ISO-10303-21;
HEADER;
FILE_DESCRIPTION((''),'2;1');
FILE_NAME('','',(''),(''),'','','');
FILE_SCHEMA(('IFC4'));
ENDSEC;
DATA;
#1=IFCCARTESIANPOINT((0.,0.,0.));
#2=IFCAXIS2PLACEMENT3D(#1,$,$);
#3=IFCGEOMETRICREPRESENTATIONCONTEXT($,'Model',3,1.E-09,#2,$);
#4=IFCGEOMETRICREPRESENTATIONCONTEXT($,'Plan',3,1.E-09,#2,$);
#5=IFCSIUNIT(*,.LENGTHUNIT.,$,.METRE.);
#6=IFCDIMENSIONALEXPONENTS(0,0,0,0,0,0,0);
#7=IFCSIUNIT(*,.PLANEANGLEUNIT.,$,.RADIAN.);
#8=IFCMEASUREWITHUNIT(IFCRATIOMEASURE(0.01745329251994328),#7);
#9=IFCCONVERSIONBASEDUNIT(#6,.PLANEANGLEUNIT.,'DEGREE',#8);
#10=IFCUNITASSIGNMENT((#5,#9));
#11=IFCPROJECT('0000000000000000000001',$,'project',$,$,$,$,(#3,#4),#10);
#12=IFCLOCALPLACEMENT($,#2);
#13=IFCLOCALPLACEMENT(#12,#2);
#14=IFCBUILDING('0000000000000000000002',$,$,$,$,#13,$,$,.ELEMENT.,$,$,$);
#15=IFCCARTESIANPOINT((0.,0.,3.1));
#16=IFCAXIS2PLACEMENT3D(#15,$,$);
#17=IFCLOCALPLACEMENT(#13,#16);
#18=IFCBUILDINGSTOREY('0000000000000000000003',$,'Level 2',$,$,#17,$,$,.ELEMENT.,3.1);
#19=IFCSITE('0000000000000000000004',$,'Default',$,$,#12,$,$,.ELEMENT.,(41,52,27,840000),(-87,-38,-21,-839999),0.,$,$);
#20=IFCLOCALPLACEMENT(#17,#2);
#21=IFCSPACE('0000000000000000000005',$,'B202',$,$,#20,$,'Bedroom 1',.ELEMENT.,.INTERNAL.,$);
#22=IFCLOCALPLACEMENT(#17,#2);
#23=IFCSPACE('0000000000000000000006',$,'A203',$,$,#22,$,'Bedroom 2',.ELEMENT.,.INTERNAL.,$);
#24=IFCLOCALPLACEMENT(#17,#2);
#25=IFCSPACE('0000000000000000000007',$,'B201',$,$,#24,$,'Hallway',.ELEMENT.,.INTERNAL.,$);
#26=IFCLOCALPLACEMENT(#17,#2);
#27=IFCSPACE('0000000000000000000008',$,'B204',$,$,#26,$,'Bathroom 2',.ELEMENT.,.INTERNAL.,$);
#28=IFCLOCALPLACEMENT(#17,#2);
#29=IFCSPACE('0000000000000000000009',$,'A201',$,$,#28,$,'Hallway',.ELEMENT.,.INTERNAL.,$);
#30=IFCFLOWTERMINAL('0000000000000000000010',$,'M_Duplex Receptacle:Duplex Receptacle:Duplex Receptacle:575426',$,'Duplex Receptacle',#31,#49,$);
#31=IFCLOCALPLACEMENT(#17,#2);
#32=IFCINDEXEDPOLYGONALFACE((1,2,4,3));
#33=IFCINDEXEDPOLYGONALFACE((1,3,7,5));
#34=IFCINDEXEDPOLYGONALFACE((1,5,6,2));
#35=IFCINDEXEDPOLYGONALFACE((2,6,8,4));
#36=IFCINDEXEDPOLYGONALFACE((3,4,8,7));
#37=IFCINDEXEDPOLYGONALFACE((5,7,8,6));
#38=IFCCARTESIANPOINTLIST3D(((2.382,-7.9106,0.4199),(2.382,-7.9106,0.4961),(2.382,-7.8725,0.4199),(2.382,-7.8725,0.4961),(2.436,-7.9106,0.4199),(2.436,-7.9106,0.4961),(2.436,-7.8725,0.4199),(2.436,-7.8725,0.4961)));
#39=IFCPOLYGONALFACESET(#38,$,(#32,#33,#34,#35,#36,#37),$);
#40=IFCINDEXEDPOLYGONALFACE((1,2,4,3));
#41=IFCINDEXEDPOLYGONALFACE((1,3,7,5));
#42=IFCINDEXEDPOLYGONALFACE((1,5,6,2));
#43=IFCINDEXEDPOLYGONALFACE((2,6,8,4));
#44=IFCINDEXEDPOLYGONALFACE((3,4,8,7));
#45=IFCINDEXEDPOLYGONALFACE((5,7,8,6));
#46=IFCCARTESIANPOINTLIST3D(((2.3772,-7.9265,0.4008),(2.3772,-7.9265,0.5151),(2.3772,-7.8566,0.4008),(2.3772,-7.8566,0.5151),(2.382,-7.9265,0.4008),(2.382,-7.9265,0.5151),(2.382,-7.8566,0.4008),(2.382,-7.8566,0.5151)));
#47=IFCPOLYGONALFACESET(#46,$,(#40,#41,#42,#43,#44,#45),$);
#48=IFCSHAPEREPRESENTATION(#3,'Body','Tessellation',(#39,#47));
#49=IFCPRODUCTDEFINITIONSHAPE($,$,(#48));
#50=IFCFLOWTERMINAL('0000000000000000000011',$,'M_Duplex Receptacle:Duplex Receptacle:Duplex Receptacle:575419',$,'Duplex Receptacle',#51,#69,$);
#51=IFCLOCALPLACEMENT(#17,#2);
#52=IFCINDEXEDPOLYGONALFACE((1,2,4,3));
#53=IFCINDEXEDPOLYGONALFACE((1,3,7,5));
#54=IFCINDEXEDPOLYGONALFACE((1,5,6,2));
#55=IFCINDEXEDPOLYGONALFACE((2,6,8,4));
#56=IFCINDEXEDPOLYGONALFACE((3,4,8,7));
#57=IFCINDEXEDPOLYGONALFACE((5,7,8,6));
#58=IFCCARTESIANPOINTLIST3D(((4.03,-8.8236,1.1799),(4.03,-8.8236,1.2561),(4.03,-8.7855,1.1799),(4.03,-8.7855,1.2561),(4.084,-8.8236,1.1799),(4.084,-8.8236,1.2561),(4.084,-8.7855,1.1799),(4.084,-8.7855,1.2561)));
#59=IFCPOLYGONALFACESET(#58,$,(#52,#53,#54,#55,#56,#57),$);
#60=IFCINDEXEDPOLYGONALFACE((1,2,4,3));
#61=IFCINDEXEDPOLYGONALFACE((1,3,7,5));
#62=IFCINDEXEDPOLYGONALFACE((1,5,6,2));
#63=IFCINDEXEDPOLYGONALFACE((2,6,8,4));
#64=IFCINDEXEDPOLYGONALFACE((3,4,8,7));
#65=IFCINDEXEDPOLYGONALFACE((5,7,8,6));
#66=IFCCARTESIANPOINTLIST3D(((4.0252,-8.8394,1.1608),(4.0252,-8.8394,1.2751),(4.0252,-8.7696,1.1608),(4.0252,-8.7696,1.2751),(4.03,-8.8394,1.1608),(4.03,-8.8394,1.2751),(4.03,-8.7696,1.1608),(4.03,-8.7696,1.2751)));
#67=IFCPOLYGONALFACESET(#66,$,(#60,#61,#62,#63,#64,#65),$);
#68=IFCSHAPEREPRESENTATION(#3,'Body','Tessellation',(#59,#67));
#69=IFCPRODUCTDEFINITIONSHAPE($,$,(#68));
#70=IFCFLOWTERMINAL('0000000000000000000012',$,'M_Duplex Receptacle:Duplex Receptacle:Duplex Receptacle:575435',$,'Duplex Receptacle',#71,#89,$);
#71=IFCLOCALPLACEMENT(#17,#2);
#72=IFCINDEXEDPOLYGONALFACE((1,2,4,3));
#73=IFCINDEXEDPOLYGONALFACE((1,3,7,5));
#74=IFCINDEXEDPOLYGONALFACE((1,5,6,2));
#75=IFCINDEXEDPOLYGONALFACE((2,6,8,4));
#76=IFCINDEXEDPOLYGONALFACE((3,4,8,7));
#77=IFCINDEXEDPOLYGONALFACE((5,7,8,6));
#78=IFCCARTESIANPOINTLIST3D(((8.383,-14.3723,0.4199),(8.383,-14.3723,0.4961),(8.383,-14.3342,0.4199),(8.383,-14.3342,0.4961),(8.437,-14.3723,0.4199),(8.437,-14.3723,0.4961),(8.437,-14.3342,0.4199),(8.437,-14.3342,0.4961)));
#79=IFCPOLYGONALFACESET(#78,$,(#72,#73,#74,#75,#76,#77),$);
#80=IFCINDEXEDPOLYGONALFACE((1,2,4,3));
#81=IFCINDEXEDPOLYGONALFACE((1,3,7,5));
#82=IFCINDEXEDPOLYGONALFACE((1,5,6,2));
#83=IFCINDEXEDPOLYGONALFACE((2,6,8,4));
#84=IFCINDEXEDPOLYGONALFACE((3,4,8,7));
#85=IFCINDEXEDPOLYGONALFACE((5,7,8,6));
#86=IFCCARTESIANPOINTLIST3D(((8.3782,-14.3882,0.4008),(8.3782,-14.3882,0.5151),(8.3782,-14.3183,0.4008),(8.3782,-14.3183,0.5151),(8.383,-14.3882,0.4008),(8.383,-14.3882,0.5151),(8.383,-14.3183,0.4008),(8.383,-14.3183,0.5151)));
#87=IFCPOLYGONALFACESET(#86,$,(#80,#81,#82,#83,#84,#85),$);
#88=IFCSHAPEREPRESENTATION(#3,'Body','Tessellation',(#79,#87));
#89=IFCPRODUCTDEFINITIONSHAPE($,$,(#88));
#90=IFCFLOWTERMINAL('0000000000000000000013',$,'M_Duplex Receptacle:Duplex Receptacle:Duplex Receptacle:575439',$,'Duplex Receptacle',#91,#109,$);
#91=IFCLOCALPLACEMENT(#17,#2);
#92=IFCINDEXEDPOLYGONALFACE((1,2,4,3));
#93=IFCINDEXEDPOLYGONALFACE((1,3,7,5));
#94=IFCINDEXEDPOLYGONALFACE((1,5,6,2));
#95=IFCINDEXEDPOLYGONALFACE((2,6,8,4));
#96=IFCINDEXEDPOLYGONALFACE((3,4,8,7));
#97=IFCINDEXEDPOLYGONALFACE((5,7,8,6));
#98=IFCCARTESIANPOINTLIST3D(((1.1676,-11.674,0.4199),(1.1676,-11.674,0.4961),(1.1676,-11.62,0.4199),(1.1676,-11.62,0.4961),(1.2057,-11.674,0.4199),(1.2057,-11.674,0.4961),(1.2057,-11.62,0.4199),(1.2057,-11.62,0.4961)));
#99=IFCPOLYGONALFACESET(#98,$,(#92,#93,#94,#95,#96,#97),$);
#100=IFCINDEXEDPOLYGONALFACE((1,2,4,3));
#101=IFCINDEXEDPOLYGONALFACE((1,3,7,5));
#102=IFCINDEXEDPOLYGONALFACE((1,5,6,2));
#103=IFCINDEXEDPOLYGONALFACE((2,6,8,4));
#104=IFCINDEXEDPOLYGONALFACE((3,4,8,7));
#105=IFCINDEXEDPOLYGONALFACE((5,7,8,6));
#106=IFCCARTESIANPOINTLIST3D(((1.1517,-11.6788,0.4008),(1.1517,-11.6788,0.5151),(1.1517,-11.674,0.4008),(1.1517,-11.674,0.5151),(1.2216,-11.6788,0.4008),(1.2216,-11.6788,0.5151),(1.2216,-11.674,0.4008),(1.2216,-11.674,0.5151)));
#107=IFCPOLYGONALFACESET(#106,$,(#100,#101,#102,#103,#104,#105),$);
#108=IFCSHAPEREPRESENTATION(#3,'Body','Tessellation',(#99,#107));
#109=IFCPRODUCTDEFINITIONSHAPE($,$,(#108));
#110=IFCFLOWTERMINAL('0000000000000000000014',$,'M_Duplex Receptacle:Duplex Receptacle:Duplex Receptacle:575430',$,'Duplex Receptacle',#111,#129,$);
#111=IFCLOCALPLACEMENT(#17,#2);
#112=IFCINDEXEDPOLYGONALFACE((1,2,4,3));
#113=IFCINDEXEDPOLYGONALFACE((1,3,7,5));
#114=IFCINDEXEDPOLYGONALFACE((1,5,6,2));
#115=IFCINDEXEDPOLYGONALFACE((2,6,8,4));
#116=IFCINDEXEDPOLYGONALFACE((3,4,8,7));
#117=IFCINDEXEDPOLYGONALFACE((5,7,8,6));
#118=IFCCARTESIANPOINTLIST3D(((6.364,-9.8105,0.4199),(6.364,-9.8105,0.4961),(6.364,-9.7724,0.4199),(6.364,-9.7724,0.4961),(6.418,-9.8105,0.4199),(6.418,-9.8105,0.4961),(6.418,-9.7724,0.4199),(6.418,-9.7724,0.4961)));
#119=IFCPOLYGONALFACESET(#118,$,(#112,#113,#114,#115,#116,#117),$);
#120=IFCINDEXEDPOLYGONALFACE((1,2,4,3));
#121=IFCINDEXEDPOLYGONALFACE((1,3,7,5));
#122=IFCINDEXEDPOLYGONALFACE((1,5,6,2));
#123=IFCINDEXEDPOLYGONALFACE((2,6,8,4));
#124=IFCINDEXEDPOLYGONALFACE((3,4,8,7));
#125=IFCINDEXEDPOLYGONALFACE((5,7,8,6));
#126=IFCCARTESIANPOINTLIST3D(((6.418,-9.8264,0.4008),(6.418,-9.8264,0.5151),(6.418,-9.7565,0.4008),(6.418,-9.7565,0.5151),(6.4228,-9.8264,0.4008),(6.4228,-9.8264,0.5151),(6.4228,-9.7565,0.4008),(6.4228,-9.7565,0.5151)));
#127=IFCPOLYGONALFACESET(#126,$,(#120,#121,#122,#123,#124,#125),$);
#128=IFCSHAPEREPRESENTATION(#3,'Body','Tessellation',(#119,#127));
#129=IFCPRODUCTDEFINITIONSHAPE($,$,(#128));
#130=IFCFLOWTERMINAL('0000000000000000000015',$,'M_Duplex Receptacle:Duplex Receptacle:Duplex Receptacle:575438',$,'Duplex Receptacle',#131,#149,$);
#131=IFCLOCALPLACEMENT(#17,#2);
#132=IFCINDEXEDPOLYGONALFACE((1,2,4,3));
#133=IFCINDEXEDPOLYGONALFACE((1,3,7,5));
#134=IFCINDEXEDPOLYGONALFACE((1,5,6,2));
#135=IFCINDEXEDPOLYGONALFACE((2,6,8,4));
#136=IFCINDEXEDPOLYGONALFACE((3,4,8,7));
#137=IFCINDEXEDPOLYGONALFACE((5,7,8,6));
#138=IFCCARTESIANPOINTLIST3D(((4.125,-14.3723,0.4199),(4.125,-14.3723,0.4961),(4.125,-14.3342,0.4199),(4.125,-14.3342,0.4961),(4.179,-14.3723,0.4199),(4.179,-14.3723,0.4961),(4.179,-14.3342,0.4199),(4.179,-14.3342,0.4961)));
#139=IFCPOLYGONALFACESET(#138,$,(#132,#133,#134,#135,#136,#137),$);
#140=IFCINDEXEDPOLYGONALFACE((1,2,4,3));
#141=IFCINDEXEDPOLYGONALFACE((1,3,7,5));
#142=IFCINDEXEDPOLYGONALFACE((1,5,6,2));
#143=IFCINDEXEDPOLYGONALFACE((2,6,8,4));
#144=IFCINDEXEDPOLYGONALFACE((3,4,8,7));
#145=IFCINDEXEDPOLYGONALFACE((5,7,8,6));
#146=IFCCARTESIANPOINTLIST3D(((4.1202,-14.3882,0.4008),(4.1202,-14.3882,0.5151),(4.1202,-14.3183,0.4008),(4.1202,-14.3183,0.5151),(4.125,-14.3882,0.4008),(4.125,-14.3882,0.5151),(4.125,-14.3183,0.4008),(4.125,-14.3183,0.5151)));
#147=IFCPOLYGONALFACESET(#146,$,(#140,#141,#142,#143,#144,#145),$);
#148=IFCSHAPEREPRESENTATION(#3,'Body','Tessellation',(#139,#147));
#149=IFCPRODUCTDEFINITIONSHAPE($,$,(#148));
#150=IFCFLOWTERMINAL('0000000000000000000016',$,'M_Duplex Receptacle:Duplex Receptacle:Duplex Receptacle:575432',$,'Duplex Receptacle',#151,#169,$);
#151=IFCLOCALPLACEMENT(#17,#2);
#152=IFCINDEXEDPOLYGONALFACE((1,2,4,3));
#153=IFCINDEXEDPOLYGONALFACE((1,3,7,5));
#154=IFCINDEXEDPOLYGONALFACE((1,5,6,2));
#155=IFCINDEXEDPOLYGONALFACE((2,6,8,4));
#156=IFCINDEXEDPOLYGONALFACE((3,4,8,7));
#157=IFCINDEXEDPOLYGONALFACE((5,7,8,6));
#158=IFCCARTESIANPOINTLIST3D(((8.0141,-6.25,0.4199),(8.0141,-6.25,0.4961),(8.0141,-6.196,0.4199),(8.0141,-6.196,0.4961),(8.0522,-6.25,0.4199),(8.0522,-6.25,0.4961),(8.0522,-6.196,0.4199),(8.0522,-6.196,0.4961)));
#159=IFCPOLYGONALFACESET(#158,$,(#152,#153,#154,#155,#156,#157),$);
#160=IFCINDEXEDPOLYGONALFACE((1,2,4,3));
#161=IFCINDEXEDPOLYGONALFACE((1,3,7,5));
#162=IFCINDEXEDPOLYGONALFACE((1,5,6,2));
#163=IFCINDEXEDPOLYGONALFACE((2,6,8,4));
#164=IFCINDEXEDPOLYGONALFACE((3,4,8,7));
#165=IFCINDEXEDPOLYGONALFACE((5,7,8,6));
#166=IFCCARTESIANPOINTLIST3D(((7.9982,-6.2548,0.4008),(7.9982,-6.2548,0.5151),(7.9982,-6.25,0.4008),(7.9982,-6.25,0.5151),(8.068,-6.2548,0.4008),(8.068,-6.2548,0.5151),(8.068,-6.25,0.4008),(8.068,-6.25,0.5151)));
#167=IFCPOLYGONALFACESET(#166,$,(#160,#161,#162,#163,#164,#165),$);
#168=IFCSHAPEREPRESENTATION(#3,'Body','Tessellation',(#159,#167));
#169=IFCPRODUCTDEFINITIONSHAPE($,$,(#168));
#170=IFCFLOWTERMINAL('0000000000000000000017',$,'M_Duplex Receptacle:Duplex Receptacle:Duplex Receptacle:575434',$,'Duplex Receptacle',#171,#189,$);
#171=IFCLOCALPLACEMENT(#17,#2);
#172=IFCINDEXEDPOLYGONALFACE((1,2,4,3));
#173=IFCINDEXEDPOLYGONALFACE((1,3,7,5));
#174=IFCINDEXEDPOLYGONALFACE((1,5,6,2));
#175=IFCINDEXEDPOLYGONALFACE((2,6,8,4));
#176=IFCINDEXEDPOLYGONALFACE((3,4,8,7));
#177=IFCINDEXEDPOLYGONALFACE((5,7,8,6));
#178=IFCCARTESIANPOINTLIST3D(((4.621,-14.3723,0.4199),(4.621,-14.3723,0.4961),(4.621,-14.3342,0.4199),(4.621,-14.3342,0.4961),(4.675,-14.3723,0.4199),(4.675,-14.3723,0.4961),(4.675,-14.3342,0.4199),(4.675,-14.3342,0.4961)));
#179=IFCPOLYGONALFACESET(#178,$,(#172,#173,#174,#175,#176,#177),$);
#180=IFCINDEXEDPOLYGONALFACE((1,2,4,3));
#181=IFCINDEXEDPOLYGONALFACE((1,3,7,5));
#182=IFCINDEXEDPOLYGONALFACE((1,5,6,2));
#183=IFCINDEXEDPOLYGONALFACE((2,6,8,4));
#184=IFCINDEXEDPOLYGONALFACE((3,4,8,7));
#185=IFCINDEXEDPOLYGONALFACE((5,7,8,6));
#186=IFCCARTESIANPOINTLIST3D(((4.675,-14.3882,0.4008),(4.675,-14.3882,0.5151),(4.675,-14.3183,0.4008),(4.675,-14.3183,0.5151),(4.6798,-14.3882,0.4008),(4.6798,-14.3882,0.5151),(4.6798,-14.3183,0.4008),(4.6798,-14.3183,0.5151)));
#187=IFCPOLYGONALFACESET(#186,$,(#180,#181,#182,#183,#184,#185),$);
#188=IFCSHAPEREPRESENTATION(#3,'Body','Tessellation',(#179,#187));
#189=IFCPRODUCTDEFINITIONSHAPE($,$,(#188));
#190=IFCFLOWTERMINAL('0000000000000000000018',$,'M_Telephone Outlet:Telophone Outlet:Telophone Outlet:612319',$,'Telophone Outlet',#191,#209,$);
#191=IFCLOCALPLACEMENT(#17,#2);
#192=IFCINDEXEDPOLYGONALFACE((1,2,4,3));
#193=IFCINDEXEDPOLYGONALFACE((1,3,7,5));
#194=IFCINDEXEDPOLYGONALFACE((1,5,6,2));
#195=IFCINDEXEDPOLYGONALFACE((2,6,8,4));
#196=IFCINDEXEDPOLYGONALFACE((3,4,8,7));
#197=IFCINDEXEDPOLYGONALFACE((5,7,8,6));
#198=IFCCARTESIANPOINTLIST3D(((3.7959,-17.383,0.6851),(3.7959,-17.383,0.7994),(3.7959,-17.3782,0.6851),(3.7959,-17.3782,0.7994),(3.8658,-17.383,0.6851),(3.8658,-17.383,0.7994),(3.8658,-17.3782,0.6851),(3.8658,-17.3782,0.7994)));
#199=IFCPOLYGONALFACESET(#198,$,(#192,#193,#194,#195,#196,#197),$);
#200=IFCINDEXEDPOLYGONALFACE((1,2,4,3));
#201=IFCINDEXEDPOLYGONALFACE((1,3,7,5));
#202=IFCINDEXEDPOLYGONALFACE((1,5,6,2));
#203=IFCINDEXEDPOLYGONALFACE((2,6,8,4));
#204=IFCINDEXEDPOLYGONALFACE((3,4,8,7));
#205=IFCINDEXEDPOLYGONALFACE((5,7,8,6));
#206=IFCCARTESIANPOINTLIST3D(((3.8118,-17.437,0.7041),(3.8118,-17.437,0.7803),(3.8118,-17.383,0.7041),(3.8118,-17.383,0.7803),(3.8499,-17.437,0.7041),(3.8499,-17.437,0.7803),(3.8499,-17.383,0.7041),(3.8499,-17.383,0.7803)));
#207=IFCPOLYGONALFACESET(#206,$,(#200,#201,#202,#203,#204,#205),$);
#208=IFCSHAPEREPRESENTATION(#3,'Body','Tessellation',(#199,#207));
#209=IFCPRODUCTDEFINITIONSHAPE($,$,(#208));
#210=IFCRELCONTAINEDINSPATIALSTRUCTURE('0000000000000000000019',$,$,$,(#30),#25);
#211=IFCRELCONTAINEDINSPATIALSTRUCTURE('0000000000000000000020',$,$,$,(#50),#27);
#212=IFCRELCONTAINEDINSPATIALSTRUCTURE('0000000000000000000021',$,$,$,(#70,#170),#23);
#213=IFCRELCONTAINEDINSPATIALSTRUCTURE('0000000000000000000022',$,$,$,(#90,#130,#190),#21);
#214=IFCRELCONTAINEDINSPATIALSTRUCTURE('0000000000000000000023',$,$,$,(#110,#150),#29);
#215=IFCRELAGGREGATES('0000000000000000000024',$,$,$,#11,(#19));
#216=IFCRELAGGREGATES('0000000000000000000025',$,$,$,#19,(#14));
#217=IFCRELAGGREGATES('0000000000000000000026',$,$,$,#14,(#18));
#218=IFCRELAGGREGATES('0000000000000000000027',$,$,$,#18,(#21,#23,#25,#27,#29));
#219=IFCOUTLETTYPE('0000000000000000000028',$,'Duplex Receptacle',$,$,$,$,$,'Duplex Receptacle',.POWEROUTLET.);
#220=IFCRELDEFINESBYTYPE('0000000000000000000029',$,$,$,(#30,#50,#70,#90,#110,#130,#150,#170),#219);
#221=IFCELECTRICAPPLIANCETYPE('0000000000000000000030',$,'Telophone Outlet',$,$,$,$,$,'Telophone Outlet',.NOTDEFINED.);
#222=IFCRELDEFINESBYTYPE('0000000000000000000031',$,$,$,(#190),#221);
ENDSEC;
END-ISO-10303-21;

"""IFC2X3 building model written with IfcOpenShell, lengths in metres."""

from ifc_helpers import new_model, entity, si_unit, converted_unit, frame, origin, origin_2d_with_axis, place, context, project, spatial, rectangle, extrude, source, transform, mapped, type_object, type_shapes, element, save


model = new_model("IFC2X3")

# Units and contexts
model_context = context("Model", 3, precision=1e-09, world=origin())
plan_context = context("Plan", 3, precision=1e-09, world=origin())
ifc_project = project(units=[si_unit("LENGTHUNIT", "METRE"), converted_unit("PLANEANGLEUNIT", "DEGREE", entity("IfcRatioMeasure", 0.01745329251994328), si_unit("PLANEANGLEUNIT", "RADIAN"), dimensions=[0, 0, 0, 0, 0, 0, 0])], contexts=[model_context, plan_context])

# Site, building, storey, space
site_placement = place(None, origin())
site = spatial("IfcSite", under=ifc_project, at=site_placement, Name="Default", CompositionType="ELEMENT", RefLatitude=(41, 52, 27, 840000), RefLongitude=(-87, -38, -21, -839999), RefElevation=0.0)
building_placement = place(site_placement, origin())
building = spatial("IfcBuilding", under=site, at=building_placement, CompositionType="ELEMENT")
storey_placement = place(building_placement, frame((0.0, 0.0, 3.1)))
storey = spatial("IfcBuildingStorey", under=building, at=storey_placement, Name="Level 2", CompositionType="ELEMENT", Elevation=3.1)
space_1_placement = place(storey_placement, origin())
space_1 = spatial("IfcSpace", under=storey, at=space_1_placement, Name="B202", LongName="Bedroom 1", CompositionType="ELEMENT", InteriorOrExteriorSpace="INTERNAL")

# Shared definitions
shared_shape_1 = source(origin(), model_context, "Body", "SweptSolid", [
    extrude(rectangle(XDim=0.0381, YDim=0.0762, at=origin_2d_with_axis()), frame((0.0, 0.0, -0.054), z_axis=(0.0, 0.0, 1.0), x_axis=(-1.0, 0.0, 0.0)), (0.0, 0.0, 1.0), 0.054),
    extrude(rectangle(XDim=0.0698, YDim=0.1143, at=origin_2d_with_axis()), frame((0.0, 0.0, 0.0), z_axis=(0.0, 0.0, 1.0), x_axis=(-1.0, 0.0, 0.0)), (0.0, 0.0, 1.0), 0.0048),
])

# Shared definitions
space_2_placement = place(storey_placement, origin())
space_2 = spatial("IfcSpace", under=storey, at=space_2_placement, Name="A203", LongName="Bedroom 2", CompositionType="ELEMENT", InteriorOrExteriorSpace="INTERNAL")

# Shared definitions
space_3_placement = place(storey_placement, origin())
space_3 = spatial("IfcSpace", under=storey, at=space_3_placement, Name="B201", LongName="Hallway", CompositionType="ELEMENT", InteriorOrExteriorSpace="INTERNAL")

# Shared definitions
space_4_placement = place(storey_placement, origin())
space_4 = spatial("IfcSpace", under=storey, at=space_4_placement, Name="B204", LongName="Bathroom 2", CompositionType="ELEMENT", InteriorOrExteriorSpace="INTERNAL")

# Shared definitions
space_5_placement = place(storey_placement, origin())
space_5 = spatial("IfcSpace", under=storey, at=space_5_placement, Name="A201", LongName="Hallway", CompositionType="ELEMENT", InteriorOrExteriorSpace="INTERNAL")

# Flow terminals
outlet_type = type_object("IfcOutletType", Name="Duplex Receptacle", ElementType="Duplex Receptacle", PredefinedType="POWEROUTLET")
type_shapes(outlet_type, [shared_shape_1])
flow_terminal_1_placement = place(space_3_placement, frame((2.382, -7.8916, 0.458), z_axis=(-1.0, 0.0, 0.0), x_axis=(0.0, -1.0, 0.0)))
element("IfcFlowTerminal", 1, at=flow_terminal_1_placement, inside=space_3, type_object=outlet_type, Name="M_Duplex Receptacle:Duplex Receptacle:Duplex Receptacle:575426", ObjectType="Duplex Receptacle", context=model_context, shape_type="MappedRepresentation", body=[
    mapped(shared_shape_1, transform((0.0, 0.0, 0.0), scale=1.0)),
])
flow_terminal_2_placement = place(space_4_placement, frame((4.03, -8.8045, 1.218), z_axis=(-1.0, 0.0, 0.0), x_axis=(0.0, -1.0, 0.0)))
element("IfcFlowTerminal", 2, at=flow_terminal_2_placement, inside=space_4, type_object=outlet_type, Name="M_Duplex Receptacle:Duplex Receptacle:Duplex Receptacle:575419", ObjectType="Duplex Receptacle", context=model_context, shape_type="MappedRepresentation", body=[
    mapped(shared_shape_1, transform((0.0, 0.0, 0.0), scale=1.0)),
])
flow_terminal_3_placement = place(space_2_placement, frame((8.383, -14.3533, 0.458), z_axis=(-1.0, 0.0, 0.0), x_axis=(0.0, -1.0, 0.0)))
element("IfcFlowTerminal", 3, at=flow_terminal_3_placement, inside=space_2, type_object=outlet_type, Name="M_Duplex Receptacle:Duplex Receptacle:Duplex Receptacle:575435", ObjectType="Duplex Receptacle", context=model_context, shape_type="MappedRepresentation", body=[
    mapped(shared_shape_1, transform((0.0, 0.0, 0.0), scale=1.0)),
])
flow_terminal_4_placement = place(space_1_placement, frame((1.1866, -11.674, 0.458), z_axis=(0.0, -1.0, 0.0), x_axis=(1.0, 0.0, 0.0)))
element("IfcFlowTerminal", 4, at=flow_terminal_4_placement, inside=space_1, type_object=outlet_type, Name="M_Duplex Receptacle:Duplex Receptacle:Duplex Receptacle:575439", ObjectType="Duplex Receptacle", context=model_context, shape_type="MappedRepresentation", body=[
    mapped(shared_shape_1, transform((0.0, 0.0, 0.0), scale=1.0)),
])
flow_terminal_5_placement = place(space_5_placement, frame((6.418, -9.7914, 0.458), z_axis=(1.0, 0.0, 0.0), x_axis=(0.0, 1.0, 0.0)))
element("IfcFlowTerminal", 5, at=flow_terminal_5_placement, inside=space_5, type_object=outlet_type, Name="M_Duplex Receptacle:Duplex Receptacle:Duplex Receptacle:575430", ObjectType="Duplex Receptacle", context=model_context, shape_type="MappedRepresentation", body=[
    mapped(shared_shape_1, transform((0.0, 0.0, 0.0), scale=1.0)),
])
flow_terminal_6_placement = place(space_1_placement, frame((4.125, -14.3533, 0.458), z_axis=(-1.0, 0.0, 0.0), x_axis=(0.0, -1.0, 0.0)))
element("IfcFlowTerminal", 6, at=flow_terminal_6_placement, inside=space_1, type_object=outlet_type, Name="M_Duplex Receptacle:Duplex Receptacle:Duplex Receptacle:575438", ObjectType="Duplex Receptacle", context=model_context, shape_type="MappedRepresentation", body=[
    mapped(shared_shape_1, transform((0.0, 0.0, 0.0), scale=1.0)),
])
flow_terminal_7_placement = place(space_5_placement, frame((8.0331, -6.25, 0.458), z_axis=(0.0, -1.0, 0.0), x_axis=(1.0, 0.0, 0.0)))
element("IfcFlowTerminal", 7, at=flow_terminal_7_placement, inside=space_5, type_object=outlet_type, Name="M_Duplex Receptacle:Duplex Receptacle:Duplex Receptacle:575432", ObjectType="Duplex Receptacle", context=model_context, shape_type="MappedRepresentation", body=[
    mapped(shared_shape_1, transform((0.0, 0.0, 0.0), scale=1.0)),
])
flow_terminal_8_placement = place(space_2_placement, frame((4.675, -14.3533, 0.458), z_axis=(1.0, 0.0, 0.0), x_axis=(0.0, 1.0, 0.0)))
element("IfcFlowTerminal", 8, at=flow_terminal_8_placement, inside=space_2, type_object=outlet_type, Name="M_Duplex Receptacle:Duplex Receptacle:Duplex Receptacle:575434", ObjectType="Duplex Receptacle", context=model_context, shape_type="MappedRepresentation", body=[
    mapped(shared_shape_1, transform((0.0, 0.0, 0.0), scale=1.0)),
])
electric_appliance_type = type_object("IfcElectricApplianceType", Name="Telophone Outlet", ElementType="Telophone Outlet", PredefinedType="NOTDEFINED")
shared_shape_2 = source(origin(), model_context, "Body", "SweptSolid", [
    extrude(rectangle(XDim=0.0699, YDim=0.1143, at=origin_2d_with_axis()), frame((0.0, 0.0, 0.0), z_axis=(0.0, 0.0, 1.0), x_axis=(-1.0, 0.0, 0.0)), (0.0, 0.0, 1.0), 0.0048),
    extrude(rectangle(XDim=0.0381, YDim=0.0762, at=origin_2d_with_axis()), frame((0.0, 0.0, -0.054), z_axis=(0.0, 0.0, 1.0), x_axis=(-1.0, 0.0, 0.0)), (0.0, 0.0, 1.0), 0.054),
])
type_shapes(electric_appliance_type, [shared_shape_2])
flow_terminal_9_placement = place(space_1_placement, frame((3.8309, -17.383, 0.7422), z_axis=(0.0, 1.0, 0.0), x_axis=(-1.0, 0.0, 0.0)))
element("IfcFlowTerminal", 9, at=flow_terminal_9_placement, inside=space_1, type_object=electric_appliance_type, Name="M_Telephone Outlet:Telophone Outlet:Telophone Outlet:612319", ObjectType="Telophone Outlet", context=model_context, shape_type="MappedRepresentation", body=[
    mapped(shared_shape_2, transform((0.0, 0.0, 0.0), scale=1.0)),
])

save(model, "model.ifc")
